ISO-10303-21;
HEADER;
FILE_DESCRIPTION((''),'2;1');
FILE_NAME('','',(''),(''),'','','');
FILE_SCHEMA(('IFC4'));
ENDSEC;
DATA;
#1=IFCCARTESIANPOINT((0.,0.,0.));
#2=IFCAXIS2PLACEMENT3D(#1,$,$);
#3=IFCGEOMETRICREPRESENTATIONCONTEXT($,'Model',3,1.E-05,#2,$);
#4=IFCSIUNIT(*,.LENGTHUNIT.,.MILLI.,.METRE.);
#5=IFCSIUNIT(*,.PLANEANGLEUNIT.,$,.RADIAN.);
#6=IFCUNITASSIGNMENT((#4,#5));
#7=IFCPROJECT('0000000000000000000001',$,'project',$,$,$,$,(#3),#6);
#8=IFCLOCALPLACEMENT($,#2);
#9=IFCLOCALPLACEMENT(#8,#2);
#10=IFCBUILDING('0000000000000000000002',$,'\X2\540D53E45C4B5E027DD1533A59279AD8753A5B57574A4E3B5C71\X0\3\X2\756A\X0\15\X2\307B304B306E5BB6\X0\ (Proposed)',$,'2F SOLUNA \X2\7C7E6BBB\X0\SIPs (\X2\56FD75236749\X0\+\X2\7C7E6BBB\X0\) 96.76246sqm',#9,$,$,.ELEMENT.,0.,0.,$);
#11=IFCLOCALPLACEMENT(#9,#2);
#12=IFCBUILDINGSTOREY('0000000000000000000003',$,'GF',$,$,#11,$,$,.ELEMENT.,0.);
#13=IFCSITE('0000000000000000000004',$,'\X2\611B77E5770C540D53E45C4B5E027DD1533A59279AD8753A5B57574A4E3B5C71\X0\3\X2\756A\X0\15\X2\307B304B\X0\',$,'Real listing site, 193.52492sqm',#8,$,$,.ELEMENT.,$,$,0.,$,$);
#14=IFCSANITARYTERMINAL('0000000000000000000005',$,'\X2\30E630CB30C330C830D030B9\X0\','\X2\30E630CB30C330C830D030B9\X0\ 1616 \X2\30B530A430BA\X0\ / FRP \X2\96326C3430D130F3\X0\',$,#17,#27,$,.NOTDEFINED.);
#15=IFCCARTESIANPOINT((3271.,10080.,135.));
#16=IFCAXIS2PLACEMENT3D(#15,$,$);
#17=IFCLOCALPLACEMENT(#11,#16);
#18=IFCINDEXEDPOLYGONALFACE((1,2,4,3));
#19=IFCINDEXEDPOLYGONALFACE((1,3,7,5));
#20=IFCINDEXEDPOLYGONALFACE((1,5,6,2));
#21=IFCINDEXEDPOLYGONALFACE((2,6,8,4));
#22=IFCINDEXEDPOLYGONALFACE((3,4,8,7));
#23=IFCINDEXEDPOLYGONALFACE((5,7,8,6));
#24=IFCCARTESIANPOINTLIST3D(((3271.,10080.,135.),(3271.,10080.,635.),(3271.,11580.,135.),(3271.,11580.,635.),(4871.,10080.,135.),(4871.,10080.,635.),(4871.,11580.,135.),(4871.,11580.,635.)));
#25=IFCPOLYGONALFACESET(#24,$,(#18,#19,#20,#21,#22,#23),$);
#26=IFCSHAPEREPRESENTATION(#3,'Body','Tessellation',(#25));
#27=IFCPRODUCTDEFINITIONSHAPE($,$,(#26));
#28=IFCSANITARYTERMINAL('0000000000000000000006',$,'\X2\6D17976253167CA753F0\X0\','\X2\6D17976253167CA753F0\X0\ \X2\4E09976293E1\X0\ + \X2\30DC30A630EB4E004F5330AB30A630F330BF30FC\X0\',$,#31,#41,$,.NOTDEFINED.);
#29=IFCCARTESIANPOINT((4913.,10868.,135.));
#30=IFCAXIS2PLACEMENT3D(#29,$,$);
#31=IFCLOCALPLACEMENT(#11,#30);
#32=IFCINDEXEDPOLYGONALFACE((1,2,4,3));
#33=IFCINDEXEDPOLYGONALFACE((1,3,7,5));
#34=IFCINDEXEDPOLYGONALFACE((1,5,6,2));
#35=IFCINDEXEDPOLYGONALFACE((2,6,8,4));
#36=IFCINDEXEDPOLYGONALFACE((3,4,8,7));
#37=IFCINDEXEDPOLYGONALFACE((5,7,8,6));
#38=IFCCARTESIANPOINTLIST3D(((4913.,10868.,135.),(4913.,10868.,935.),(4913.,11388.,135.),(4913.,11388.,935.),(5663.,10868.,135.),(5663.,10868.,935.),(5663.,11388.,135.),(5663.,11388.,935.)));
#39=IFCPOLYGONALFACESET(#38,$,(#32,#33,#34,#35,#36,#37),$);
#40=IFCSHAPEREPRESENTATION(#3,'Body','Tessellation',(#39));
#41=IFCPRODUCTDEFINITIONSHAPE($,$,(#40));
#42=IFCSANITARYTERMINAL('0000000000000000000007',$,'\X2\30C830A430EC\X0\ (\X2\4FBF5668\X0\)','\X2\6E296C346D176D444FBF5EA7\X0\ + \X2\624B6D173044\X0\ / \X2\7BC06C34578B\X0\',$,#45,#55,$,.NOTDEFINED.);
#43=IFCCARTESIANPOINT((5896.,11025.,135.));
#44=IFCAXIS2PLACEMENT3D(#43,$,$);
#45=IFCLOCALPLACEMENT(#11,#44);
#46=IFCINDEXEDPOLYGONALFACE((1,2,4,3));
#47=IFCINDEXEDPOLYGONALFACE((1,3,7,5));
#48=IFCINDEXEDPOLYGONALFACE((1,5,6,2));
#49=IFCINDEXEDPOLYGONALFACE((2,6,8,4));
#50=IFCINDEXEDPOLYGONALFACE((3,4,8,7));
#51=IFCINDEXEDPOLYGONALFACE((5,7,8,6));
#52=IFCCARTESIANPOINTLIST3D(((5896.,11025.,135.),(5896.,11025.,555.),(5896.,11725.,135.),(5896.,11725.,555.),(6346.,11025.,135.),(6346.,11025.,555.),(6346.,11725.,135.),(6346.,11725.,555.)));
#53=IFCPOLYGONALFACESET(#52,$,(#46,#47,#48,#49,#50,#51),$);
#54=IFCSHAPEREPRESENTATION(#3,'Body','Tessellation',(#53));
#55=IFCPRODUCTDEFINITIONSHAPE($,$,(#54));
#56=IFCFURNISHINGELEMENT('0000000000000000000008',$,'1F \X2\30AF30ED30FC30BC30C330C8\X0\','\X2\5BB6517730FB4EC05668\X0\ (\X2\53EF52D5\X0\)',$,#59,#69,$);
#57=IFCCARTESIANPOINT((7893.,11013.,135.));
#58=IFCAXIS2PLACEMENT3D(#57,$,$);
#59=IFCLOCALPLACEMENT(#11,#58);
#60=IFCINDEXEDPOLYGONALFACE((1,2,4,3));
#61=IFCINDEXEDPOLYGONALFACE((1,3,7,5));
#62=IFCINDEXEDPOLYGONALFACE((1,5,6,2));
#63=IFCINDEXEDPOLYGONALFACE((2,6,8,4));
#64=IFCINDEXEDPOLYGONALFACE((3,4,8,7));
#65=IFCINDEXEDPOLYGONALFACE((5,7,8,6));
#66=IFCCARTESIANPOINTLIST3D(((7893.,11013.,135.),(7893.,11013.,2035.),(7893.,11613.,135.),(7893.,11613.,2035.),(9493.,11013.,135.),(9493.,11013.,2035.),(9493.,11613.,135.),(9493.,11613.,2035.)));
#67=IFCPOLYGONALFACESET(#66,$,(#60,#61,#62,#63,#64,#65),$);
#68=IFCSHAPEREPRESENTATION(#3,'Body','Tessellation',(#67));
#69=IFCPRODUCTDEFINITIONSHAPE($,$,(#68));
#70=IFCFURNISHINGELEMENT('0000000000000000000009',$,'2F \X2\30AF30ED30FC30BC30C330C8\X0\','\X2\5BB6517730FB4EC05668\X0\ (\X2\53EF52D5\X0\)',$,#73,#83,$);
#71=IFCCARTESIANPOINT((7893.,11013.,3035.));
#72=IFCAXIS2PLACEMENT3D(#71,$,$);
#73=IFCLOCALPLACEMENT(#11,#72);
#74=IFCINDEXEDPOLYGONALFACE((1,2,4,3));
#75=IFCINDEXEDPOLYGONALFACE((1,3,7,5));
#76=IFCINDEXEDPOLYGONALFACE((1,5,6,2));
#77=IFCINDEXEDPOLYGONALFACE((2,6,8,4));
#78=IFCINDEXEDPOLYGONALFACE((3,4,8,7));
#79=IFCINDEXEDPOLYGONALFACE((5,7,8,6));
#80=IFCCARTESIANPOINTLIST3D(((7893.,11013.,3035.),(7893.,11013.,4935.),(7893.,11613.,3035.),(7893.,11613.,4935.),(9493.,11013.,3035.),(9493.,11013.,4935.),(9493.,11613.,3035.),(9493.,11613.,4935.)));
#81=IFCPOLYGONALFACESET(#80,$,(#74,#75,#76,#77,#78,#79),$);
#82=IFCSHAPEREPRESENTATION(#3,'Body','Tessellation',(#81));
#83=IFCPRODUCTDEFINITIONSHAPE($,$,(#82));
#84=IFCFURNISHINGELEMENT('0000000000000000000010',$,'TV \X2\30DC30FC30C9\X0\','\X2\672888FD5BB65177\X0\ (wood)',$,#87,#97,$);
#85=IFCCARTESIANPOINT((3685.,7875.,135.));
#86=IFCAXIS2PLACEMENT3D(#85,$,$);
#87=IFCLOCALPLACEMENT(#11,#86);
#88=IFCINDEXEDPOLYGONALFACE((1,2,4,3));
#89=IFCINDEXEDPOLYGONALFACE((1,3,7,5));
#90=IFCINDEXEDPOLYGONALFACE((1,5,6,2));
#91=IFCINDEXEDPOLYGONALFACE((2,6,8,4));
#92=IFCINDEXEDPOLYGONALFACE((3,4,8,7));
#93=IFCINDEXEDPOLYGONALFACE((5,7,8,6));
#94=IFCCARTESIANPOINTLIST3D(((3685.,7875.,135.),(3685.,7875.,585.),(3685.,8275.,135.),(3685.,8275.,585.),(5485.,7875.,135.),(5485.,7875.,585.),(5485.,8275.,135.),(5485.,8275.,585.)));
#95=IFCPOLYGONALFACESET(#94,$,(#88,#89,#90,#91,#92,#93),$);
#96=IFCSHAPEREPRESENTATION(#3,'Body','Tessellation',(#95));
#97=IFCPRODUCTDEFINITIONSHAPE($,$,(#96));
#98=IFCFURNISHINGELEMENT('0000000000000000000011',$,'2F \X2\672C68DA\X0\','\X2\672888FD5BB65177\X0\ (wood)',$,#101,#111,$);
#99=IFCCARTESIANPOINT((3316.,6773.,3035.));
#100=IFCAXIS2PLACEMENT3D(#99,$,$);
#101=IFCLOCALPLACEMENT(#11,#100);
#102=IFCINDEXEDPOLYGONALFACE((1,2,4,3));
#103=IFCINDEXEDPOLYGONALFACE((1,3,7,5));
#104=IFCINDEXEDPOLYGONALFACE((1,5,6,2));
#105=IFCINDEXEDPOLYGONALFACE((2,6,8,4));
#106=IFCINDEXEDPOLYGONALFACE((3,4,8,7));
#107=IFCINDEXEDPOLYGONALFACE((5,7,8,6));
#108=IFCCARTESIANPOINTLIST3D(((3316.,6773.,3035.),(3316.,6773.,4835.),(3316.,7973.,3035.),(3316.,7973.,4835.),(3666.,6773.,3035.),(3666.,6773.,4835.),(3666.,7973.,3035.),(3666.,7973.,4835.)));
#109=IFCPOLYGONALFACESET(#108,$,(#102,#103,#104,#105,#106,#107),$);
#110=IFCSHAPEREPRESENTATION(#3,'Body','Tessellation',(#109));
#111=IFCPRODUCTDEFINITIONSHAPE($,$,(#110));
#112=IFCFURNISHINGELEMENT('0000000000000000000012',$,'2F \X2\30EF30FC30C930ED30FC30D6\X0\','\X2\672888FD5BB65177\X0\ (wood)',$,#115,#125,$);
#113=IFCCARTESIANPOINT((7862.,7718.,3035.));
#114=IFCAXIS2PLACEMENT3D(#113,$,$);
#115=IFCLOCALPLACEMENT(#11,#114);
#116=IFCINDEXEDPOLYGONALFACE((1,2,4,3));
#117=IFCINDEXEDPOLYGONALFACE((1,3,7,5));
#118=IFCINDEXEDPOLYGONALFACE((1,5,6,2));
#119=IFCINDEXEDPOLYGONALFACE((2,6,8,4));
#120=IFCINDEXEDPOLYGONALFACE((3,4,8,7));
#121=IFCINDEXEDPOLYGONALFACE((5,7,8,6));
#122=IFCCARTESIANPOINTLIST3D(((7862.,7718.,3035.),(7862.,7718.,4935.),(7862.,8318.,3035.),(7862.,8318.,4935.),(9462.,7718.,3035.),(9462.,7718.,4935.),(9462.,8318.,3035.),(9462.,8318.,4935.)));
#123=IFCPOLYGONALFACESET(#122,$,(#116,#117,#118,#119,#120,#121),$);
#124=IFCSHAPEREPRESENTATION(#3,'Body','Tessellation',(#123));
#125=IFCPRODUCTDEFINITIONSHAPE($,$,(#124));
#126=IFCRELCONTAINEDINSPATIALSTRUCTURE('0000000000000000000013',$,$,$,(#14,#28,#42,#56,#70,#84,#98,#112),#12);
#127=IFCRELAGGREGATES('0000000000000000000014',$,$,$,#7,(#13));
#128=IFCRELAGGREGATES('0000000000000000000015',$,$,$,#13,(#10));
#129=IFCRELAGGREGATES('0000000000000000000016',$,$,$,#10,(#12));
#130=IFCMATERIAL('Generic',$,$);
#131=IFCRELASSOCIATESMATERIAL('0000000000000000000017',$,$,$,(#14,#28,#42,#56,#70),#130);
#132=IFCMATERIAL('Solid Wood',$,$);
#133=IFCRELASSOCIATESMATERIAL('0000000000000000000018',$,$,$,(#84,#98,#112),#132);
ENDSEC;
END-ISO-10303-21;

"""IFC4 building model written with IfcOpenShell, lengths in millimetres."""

from ifc_helpers import new_model, si_unit, frame, frame_2d, origin, place, context, project, spatial, rectangle, extrude, material, element, save


model = new_model("IFC4")

# Units and contexts
model_context = context("Model", 3, precision=1e-05, world=origin())
ifc_project = project(units=[si_unit("LENGTHUNIT", "METRE", prefix="MILLI"), si_unit("PLANEANGLEUNIT", "RADIAN")], contexts=[model_context])

# Site, building, storey
site_placement = place(None, origin())
site = spatial("IfcSite", under=ifc_project, at=site_placement, Name="愛知県名古屋市緑区大高町字坊主山3番15ほか", ObjectType="Real listing site, 193.52492sqm", CompositionType="ELEMENT", RefElevation=0.0)
building_placement = place(site_placement, origin())
building = spatial("IfcBuilding", under=site, at=building_placement, Name="名古屋市緑区大高町字坊主山3番15ほかの家 (Proposed)", ObjectType="2F SOLUNA 籾殻SIPs (国産杉+籾殻) 96.76246sqm", CompositionType="ELEMENT", ElevationOfRefHeight=0.0, ElevationOfTerrain=0.0)
storey_placement = place(building_placement, origin())
storey = spatial("IfcBuildingStorey", under=building, at=storey_placement, Name="GF", CompositionType="ELEMENT", Elevation=0.0)

# Shared definitions
ifc_material_1 = material(Name="Solid Wood")

# Sanitary terminals
ifc_material_2 = material(Name="Generic")
sanitary_terminal_1_placement = place(storey_placement, frame((3271.0, 10080.0, 135.0)))
element("IfcSanitaryTerminal", 1, at=sanitary_terminal_1_placement, inside=storey, material=ifc_material_2, Name="ユニットバス", Description="ユニットバス 1616 サイズ / FRP 防水パン", PredefinedType="NOTDEFINED", context=model_context, shape_type="SweptSolid", body=[
    extrude(rectangle(XDim=1600.0, YDim=1500.0, at=frame_2d((800.0, 750.0))), frame((3271.0, 10080.0, 135.0)), (0.0, 0.0, 1.0), 500.0),
])
sanitary_terminal_2_placement = place(storey_placement, frame((4913.0, 10868.0, 135.0)))
element("IfcSanitaryTerminal", 2, at=sanitary_terminal_2_placement, inside=storey, material=ifc_material_2, Name="洗面化粧台", Description="洗面化粧台 三面鏡 + ボウル一体カウンター", PredefinedType="NOTDEFINED", context=model_context, shape_type="SweptSolid", body=[
    extrude(rectangle(XDim=750.0, YDim=520.0, at=frame_2d((375.0, 260.0))), frame((4913.0, 10868.0, 135.0)), (0.0, 0.0, 1.0), 800.0),
])
sanitary_terminal_3_placement = place(storey_placement, frame((5896.0, 11025.0, 135.0)))
element("IfcSanitaryTerminal", 3, at=sanitary_terminal_3_placement, inside=storey, material=ifc_material_2, Name="トイレ (便器)", Description="温水洗浄便座 + 手洗い / 節水型", PredefinedType="NOTDEFINED", context=model_context, shape_type="SweptSolid", body=[
    extrude(rectangle(XDim=450.0, YDim=700.0, at=frame_2d((225.0, 350.0))), frame((5896.0, 11025.0, 135.0)), (0.0, 0.0, 1.0), 420.0),
])

# Furnishing elements
furnishing_1_placement = place(storey_placement, frame((7893.0, 11013.0, 135.0)))
element("IfcFurnishingElement", 4, at=furnishing_1_placement, inside=storey, material=ifc_material_2, Name="1F クローゼット", Description="家具・什器 (可動)", context=model_context, shape_type="SweptSolid", body=[
    extrude(rectangle(XDim=1600.0, YDim=600.0, at=frame_2d((800.0, 300.0))), frame((7893.0, 11013.0, 135.0)), (0.0, 0.0, 1.0), 1900.0),
])
furnishing_2_placement = place(storey_placement, frame((7893.0, 11013.0, 3035.0)))
element("IfcFurnishingElement", 5, at=furnishing_2_placement, inside=storey, material=ifc_material_2, Name="2F クローゼット", Description="家具・什器 (可動)", context=model_context, shape_type="SweptSolid", body=[
    extrude(rectangle(XDim=1600.0, YDim=600.0, at=frame_2d((800.0, 300.0))), frame((7893.0, 11013.0, 3035.0)), (0.0, 0.0, 1.0), 1900.0),
])
furnishing_3_placement = place(storey_placement, frame((3685.0, 7875.0, 135.0)))
element("IfcFurnishingElement", 6, at=furnishing_3_placement, inside=storey, material=ifc_material_1, Name="TV ボード", Description="木製家具 (wood)", context=model_context, shape_type="SweptSolid", body=[
    extrude(rectangle(XDim=1800.0, YDim=400.0, at=frame_2d((900.0, 200.0))), frame((3685.0, 7875.0, 135.0)), (0.0, 0.0, 1.0), 450.0),
])
furnishing_4_placement = place(storey_placement, frame((3316.0, 6773.0, 3035.0)))
element("IfcFurnishingElement", 7, at=furnishing_4_placement, inside=storey, material=ifc_material_1, Name="2F 本棚", Description="木製家具 (wood)", context=model_context, shape_type="SweptSolid", body=[
    extrude(rectangle(XDim=350.0, YDim=1200.0, at=frame_2d((175.0, 600.0))), frame((3316.0, 6773.0, 3035.0)), (0.0, 0.0, 1.0), 1800.0),
])
furnishing_5_placement = place(storey_placement, frame((7862.0, 7718.0, 3035.0)))
element("IfcFurnishingElement", 8, at=furnishing_5_placement, inside=storey, material=ifc_material_1, Name="2F ワードローブ", Description="木製家具 (wood)", context=model_context, shape_type="SweptSolid", body=[
    extrude(rectangle(XDim=1600.0, YDim=600.0, at=frame_2d((800.0, 300.0))), frame((7862.0, 7718.0, 3035.0)), (0.0, 0.0, 1.0), 1900.0),
])

save(model, "model.ifc")
